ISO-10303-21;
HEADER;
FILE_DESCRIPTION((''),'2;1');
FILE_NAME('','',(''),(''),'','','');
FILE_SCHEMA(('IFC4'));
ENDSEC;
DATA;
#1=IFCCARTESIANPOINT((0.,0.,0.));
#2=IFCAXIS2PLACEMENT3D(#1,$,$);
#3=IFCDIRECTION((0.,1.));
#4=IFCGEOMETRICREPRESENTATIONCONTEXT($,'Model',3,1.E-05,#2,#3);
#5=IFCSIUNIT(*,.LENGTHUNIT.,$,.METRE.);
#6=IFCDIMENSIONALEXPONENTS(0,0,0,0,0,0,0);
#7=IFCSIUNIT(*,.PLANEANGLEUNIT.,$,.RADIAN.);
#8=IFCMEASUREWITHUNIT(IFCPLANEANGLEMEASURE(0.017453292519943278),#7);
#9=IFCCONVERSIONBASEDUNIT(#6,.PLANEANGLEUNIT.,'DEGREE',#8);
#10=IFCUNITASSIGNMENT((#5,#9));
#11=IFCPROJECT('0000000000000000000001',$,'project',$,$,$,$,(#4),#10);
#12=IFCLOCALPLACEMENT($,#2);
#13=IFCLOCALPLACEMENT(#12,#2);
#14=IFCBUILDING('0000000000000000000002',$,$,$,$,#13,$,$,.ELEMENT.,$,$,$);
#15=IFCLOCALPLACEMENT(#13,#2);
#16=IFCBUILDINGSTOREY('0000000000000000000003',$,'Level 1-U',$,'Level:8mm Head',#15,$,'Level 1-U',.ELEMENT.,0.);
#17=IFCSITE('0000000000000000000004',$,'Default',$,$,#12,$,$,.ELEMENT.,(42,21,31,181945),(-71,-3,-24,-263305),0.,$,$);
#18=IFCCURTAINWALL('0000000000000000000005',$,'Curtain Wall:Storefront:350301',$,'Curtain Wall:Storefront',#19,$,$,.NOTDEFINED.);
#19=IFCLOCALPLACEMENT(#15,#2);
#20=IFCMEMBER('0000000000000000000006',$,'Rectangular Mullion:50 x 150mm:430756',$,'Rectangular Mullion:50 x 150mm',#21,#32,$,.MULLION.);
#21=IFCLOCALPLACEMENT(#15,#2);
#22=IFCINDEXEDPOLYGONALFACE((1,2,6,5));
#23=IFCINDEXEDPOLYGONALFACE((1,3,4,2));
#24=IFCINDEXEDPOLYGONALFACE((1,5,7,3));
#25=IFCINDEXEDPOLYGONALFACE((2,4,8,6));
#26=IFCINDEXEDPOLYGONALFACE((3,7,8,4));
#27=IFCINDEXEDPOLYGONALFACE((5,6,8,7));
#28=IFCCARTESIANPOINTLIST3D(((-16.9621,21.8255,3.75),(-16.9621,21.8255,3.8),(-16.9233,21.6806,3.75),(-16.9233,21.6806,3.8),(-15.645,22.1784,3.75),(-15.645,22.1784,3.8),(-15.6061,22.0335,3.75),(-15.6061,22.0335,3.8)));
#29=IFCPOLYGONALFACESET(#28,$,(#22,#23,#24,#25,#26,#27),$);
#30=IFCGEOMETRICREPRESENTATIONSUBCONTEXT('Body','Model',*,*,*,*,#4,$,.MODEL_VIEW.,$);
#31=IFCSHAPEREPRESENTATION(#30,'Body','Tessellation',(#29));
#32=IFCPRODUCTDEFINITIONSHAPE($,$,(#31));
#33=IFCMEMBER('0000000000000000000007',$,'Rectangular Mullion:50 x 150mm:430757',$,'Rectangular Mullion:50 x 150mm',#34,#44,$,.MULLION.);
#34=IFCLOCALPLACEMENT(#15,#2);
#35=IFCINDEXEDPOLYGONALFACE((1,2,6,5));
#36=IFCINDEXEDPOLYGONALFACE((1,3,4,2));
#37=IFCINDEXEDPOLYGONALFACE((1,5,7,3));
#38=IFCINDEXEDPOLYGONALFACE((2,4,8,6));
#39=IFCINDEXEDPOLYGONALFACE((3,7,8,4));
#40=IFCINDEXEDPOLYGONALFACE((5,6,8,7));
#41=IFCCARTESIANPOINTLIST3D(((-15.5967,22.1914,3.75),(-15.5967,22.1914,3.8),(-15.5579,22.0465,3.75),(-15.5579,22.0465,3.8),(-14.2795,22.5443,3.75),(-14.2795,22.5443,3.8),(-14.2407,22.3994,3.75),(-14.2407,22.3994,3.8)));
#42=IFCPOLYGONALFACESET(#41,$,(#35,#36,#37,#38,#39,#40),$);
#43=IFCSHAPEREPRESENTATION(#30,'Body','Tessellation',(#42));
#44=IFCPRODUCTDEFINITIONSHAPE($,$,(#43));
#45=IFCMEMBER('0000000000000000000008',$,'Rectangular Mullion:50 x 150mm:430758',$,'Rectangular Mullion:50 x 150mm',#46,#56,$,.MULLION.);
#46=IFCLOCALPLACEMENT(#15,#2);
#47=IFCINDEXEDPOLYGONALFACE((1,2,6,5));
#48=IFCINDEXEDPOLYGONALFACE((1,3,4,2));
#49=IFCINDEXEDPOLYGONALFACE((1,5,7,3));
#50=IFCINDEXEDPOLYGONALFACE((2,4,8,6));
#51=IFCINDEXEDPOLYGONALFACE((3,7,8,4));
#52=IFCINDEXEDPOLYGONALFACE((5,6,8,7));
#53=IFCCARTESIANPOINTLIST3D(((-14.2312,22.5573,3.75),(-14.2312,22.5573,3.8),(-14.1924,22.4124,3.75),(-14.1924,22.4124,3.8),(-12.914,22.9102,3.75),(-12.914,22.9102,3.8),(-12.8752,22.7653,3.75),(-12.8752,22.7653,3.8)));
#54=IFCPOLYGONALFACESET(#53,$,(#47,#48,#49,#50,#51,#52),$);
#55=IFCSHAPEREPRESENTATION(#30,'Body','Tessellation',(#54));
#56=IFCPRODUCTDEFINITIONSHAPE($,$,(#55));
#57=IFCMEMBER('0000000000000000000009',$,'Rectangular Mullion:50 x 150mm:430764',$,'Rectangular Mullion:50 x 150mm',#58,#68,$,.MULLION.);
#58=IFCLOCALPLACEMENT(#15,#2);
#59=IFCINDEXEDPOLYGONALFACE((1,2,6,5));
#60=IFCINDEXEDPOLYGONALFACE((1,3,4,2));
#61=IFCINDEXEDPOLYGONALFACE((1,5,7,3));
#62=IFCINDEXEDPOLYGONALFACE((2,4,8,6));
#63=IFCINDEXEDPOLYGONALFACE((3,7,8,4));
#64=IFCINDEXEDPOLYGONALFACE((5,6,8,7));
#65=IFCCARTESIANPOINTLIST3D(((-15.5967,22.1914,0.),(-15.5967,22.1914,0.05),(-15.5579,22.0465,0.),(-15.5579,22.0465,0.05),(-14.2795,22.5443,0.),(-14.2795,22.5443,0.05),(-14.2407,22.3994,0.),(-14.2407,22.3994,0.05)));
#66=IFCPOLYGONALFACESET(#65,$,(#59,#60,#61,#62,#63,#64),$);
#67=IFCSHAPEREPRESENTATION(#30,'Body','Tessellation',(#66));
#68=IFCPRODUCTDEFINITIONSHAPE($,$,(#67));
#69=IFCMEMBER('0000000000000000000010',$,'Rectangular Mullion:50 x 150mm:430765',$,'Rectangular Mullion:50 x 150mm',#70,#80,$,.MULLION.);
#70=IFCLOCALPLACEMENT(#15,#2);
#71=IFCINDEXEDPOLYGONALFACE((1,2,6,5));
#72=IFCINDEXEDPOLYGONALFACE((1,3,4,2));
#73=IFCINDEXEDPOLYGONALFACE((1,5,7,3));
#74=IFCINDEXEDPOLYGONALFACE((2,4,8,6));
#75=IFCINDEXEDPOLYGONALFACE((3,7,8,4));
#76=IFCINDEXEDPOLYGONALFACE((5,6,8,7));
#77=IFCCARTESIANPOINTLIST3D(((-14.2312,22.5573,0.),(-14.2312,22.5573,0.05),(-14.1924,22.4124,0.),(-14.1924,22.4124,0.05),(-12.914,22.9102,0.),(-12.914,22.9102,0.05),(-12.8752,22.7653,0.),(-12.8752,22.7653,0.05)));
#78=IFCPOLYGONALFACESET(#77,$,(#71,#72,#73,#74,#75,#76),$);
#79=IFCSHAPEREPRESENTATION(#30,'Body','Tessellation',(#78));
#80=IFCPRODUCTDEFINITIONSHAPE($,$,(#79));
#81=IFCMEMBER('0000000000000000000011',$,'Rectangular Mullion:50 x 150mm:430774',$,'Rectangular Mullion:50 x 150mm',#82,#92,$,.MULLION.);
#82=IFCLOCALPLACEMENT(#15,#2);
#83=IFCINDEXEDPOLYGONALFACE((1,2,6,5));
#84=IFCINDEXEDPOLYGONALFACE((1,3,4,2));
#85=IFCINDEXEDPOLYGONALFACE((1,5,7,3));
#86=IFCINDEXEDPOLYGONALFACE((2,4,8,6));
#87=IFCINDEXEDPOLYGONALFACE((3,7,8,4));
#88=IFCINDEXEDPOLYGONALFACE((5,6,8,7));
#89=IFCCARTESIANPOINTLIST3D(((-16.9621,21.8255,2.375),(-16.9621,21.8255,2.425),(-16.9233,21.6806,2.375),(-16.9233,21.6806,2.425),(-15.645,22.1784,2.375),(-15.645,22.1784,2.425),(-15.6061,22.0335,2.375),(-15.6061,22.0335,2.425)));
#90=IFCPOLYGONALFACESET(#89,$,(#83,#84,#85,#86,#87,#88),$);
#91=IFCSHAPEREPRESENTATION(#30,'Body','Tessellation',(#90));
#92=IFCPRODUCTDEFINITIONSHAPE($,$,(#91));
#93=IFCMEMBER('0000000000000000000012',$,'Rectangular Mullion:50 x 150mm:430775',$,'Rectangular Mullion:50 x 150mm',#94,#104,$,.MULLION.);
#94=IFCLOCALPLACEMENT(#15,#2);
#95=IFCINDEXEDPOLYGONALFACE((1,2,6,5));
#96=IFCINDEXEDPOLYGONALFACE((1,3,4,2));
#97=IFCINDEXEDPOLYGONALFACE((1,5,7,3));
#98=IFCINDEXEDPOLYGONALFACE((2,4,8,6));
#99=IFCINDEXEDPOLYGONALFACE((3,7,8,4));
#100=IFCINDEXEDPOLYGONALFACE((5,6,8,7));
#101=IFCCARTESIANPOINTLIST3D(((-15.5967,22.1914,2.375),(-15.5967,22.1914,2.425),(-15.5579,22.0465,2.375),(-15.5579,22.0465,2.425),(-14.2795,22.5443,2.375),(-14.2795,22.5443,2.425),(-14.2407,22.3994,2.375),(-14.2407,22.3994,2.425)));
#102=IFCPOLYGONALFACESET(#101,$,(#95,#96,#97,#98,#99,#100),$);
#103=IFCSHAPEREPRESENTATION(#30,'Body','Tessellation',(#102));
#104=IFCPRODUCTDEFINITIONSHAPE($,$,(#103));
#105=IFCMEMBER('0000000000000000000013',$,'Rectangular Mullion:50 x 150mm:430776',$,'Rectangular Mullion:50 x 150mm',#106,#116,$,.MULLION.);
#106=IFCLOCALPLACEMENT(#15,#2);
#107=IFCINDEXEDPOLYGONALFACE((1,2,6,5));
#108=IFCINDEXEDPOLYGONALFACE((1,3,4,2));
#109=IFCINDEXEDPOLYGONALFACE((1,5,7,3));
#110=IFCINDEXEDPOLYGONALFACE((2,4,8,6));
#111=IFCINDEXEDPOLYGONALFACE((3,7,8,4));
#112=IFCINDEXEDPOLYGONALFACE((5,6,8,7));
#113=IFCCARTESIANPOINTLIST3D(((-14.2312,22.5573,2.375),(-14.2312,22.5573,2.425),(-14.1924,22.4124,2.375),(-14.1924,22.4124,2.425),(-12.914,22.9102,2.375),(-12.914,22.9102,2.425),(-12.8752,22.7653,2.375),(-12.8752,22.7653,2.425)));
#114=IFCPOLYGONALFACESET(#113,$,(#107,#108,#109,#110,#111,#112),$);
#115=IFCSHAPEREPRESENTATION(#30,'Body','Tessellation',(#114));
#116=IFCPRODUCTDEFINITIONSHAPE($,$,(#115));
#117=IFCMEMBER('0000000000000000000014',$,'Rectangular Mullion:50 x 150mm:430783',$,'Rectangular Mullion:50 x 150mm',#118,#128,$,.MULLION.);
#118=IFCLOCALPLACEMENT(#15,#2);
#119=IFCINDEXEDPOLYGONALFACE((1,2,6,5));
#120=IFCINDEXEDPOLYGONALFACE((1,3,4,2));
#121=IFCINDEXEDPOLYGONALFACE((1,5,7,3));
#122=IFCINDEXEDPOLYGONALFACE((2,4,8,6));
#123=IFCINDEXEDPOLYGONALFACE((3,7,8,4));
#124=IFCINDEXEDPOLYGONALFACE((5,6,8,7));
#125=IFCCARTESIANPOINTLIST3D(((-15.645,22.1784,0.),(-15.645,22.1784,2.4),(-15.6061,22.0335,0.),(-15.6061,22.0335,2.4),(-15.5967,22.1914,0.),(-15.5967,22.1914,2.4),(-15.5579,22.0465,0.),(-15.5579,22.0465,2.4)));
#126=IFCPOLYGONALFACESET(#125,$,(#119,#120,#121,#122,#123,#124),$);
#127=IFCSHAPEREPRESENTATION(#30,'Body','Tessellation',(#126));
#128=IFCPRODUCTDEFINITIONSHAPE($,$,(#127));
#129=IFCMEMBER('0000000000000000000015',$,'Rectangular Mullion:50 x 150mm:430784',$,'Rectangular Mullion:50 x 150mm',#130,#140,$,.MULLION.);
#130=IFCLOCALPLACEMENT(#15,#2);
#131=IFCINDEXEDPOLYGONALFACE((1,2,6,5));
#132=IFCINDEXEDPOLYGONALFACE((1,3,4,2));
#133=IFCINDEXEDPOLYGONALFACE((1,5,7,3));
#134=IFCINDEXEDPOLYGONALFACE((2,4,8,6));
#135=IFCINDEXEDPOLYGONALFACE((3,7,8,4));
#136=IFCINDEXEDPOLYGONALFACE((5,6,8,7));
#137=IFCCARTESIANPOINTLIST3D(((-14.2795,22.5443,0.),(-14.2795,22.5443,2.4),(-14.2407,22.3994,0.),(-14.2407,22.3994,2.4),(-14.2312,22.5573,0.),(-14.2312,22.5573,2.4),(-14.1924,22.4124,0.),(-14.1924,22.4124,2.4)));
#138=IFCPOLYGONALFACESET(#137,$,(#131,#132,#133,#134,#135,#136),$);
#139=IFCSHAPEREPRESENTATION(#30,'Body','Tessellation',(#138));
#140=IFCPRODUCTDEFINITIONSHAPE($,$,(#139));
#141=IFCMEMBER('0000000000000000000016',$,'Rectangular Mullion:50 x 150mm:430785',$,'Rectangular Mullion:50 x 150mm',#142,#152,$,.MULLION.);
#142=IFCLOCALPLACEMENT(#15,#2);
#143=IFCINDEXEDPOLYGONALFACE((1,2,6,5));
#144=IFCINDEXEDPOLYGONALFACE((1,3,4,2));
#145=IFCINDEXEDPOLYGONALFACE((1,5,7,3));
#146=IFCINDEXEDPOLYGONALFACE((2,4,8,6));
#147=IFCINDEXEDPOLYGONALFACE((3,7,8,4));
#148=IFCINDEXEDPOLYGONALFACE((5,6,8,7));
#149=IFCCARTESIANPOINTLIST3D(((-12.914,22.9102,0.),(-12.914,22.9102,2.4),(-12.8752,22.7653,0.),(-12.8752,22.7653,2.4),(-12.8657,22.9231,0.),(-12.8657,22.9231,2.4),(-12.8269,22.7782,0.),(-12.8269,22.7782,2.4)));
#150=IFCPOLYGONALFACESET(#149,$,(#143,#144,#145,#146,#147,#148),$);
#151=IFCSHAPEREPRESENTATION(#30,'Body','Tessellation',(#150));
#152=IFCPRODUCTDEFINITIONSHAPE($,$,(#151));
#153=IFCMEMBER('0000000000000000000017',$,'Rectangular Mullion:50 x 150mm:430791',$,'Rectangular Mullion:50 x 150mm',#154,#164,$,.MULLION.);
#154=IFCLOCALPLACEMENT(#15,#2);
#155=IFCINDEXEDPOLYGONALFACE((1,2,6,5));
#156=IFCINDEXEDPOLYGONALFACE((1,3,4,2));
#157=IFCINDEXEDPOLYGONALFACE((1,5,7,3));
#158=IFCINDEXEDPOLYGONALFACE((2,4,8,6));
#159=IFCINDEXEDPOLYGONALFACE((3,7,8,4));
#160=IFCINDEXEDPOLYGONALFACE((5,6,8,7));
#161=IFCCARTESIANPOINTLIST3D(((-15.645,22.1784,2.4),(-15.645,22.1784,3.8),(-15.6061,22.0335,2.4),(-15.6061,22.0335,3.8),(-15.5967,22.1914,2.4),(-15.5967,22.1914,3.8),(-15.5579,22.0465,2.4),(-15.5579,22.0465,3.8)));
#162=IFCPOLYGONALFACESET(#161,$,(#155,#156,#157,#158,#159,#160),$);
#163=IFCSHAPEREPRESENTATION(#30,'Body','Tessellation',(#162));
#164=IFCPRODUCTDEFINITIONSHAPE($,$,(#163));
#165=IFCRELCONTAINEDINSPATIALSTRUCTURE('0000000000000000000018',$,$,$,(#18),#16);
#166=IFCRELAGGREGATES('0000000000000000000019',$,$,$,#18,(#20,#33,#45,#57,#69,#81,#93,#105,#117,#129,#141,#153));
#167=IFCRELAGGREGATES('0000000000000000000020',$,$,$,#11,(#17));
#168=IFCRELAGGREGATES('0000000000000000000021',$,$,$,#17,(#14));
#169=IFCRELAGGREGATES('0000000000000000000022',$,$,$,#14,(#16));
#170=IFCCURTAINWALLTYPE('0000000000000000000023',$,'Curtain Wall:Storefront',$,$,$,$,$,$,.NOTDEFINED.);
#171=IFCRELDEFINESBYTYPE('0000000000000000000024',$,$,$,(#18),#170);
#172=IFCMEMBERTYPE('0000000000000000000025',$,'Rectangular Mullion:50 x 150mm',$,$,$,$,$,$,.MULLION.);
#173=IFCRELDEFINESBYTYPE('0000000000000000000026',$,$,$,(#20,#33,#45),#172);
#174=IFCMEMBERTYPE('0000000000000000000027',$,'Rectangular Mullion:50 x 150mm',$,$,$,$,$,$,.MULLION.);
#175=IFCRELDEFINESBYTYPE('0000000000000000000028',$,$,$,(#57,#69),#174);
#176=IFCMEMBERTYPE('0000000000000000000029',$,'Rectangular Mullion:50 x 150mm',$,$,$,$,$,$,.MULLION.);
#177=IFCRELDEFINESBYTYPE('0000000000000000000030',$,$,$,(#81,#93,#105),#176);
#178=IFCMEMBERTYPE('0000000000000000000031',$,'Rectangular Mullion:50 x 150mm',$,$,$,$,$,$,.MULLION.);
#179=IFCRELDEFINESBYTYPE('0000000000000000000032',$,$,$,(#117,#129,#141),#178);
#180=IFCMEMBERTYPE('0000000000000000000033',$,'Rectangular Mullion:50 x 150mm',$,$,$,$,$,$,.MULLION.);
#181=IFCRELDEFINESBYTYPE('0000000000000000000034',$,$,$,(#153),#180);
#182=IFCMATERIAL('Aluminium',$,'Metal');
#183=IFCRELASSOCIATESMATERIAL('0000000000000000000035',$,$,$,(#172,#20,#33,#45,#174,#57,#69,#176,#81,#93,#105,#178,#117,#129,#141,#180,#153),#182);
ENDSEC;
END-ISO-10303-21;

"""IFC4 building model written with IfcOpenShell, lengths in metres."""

from ifc_helpers import new_model, entity, si_unit, converted_unit, direction, frame, origin, place, context, subcontext, project, spatial, indexed_curve, outline, extrude, source, transform, mapped, material, type_object, type_shapes, element, aggregate, save


model = new_model("IFC4")

# Units and contexts
model_context = context("Model", 3, precision=1e-05, world=origin(), true_north=direction((0.0, 1.0)))
body_context = subcontext(model_context, "Body", "Model", "MODEL_VIEW")
ifc_project = project(units=[si_unit("LENGTHUNIT", "METRE"), converted_unit("PLANEANGLEUNIT", "DEGREE", entity("IfcPlaneAngleMeasure", 0.017453292519943278), si_unit("PLANEANGLEUNIT", "RADIAN"), dimensions=[0, 0, 0, 0, 0, 0, 0])], contexts=[model_context])

# Site, building, storey
site_placement = place(None, origin())
site = spatial("IfcSite", under=ifc_project, at=site_placement, Name="Default", CompositionType="ELEMENT", RefLatitude=(42, 21, 31, 181945), RefLongitude=(-71, -3, -24, -263305), RefElevation=0.0)
building_placement = place(site_placement, origin())
building = spatial("IfcBuilding", under=site, at=building_placement, CompositionType="ELEMENT")
storey_placement = place(building_placement, origin())
storey = spatial("IfcBuildingStorey", under=building, at=storey_placement, Name="Level 1-U", ObjectType="Level:8mm Head", LongName="Level 1-U", CompositionType="ELEMENT", Elevation=0.0)

# Curtain wall, members
curtain_wall_type = type_object("IfcCurtainWallType", Name="Curtain Wall:Storefront", PredefinedType="NOTDEFINED")
curtain_wall_placement = place(storey_placement, origin())
curtain_wall = element("IfcCurtainWall", 1, at=curtain_wall_placement, inside=storey, type_object=curtain_wall_type, Name="Curtain Wall:Storefront:350301", ObjectType="Curtain Wall:Storefront", PredefinedType="NOTDEFINED")
ifc_material_1 = material(Name="Aluminium", Category="Metal")
member_type_1 = type_object("IfcMemberType", Name="Rectangular Mullion:50 x 150mm", PredefinedType="MULLION", material=ifc_material_1)
shared_shape_1 = source(origin(), body_context, "Body", "SweptSolid", [
    extrude(outline(indexed_curve([(-0.025, -0.075), (0.025, -0.075), (0.025, 0.075), (-0.025, 0.075), (-0.025, -0.075)], self_intersect=False)), frame((-0.025, 0.0, -1.3636), z_axis=(0.0, 0.0, 1.0), x_axis=(-1.0, 0.0, 0.0)), (0.0, 0.0, 1.0), 1.3636),
])
type_shapes(member_type_1, [shared_shape_1])
member_1_placement = place(curtain_wall_placement, frame((-15.6256, 22.106, 3.8), z_axis=(0.965926, 0.258819, 0.0), x_axis=(0.0, 0.0, 1.0)))
member_1 = element("IfcMember", 2, at=member_1_placement, type_object=member_type_1, material=ifc_material_1, Name="Rectangular Mullion:50 x 150mm:430756", ObjectType="Rectangular Mullion:50 x 150mm", PredefinedType="MULLION", context=body_context, shape_type="MappedRepresentation", body=[
    mapped(shared_shape_1, transform((0.0, 0.0, 0.0), scale=1.0)),
])
member_2_placement = place(curtain_wall_placement, frame((-14.2601, 22.4719, 3.8), z_axis=(0.965926, 0.258819, 0.0), x_axis=(0.0, 0.0, 1.0)))
member_2 = element("IfcMember", 3, at=member_2_placement, type_object=member_type_1, material=ifc_material_1, Name="Rectangular Mullion:50 x 150mm:430757", ObjectType="Rectangular Mullion:50 x 150mm", PredefinedType="MULLION", context=body_context, shape_type="MappedRepresentation", body=[
    mapped(shared_shape_1, transform((0.0, 0.0, 0.0), scale=1.0)),
])
member_3_placement = place(curtain_wall_placement, frame((-12.8946, 22.8377, 3.8), z_axis=(0.965926, 0.258819, 0.0), x_axis=(0.0, 0.0, 1.0)))
member_3 = element("IfcMember", 4, at=member_3_placement, type_object=member_type_1, material=ifc_material_1, Name="Rectangular Mullion:50 x 150mm:430758", ObjectType="Rectangular Mullion:50 x 150mm", PredefinedType="MULLION", context=body_context, shape_type="MappedRepresentation", body=[
    mapped(shared_shape_1, transform((0.0, 0.0, 0.0), scale=1.0)),
])
member_type_2 = type_object("IfcMemberType", Name="Rectangular Mullion:50 x 150mm", PredefinedType="MULLION", material=ifc_material_1)
shared_shape_2 = source(origin(), body_context, "Body", "SweptSolid", [
    extrude(outline(indexed_curve([(-0.025, -0.075), (0.025, -0.075), (0.025, 0.075), (-0.025, 0.075), (-0.025, -0.075)], self_intersect=False)), frame((-0.025, 0.0, -1.3636), z_axis=(0.0, 0.0, 1.0), x_axis=(-1.0, 0.0, 0.0)), (0.0, 0.0, 1.0), 1.3636),
])
type_shapes(member_type_2, [shared_shape_2])
member_4_placement = place(curtain_wall_placement, frame((-15.5773, 22.1189, 0.0), z_axis=(-0.965926, -0.258819, 0.0), x_axis=(0.0, 0.0, -1.0)))
member_4 = element("IfcMember", 5, at=member_4_placement, type_object=member_type_2, material=ifc_material_1, Name="Rectangular Mullion:50 x 150mm:430764", ObjectType="Rectangular Mullion:50 x 150mm", PredefinedType="MULLION", context=body_context, shape_type="MappedRepresentation", body=[
    mapped(shared_shape_2, transform((0.0, 0.0, 0.0), scale=1.0)),
])
member_5_placement = place(curtain_wall_placement, frame((-14.2118, 22.4848, 0.0), z_axis=(-0.965926, -0.258819, 0.0), x_axis=(0.0, 0.0, -1.0)))
member_5 = element("IfcMember", 6, at=member_5_placement, type_object=member_type_2, material=ifc_material_1, Name="Rectangular Mullion:50 x 150mm:430765", ObjectType="Rectangular Mullion:50 x 150mm", PredefinedType="MULLION", context=body_context, shape_type="MappedRepresentation", body=[
    mapped(shared_shape_2, transform((0.0, 0.0, 0.0), scale=1.0)),
])
member_type_3 = type_object("IfcMemberType", Name="Rectangular Mullion:50 x 150mm", PredefinedType="MULLION", material=ifc_material_1)
shared_shape_3 = source(origin(), body_context, "Body", "SweptSolid", [
    extrude(outline(indexed_curve([(-0.025, -0.075), (0.025, -0.075), (0.025, 0.075), (-0.025, 0.075), (-0.025, -0.075)], self_intersect=False)), frame((0.0, 0.0, -1.3636), z_axis=(0.0, 0.0, 1.0), x_axis=(-1.0, 0.0, 0.0)), (0.0, 0.0, 1.0), 1.3636),
])
type_shapes(member_type_3, [shared_shape_3])
member_6_placement = place(curtain_wall_placement, frame((-15.6256, 22.106, 2.4), z_axis=(0.965926, 0.258819, 0.0), x_axis=(0.0, 0.0, 1.0)))
member_6 = element("IfcMember", 7, at=member_6_placement, type_object=member_type_3, material=ifc_material_1, Name="Rectangular Mullion:50 x 150mm:430774", ObjectType="Rectangular Mullion:50 x 150mm", PredefinedType="MULLION", context=body_context, shape_type="MappedRepresentation", body=[
    mapped(shared_shape_3, transform((0.0, 0.0, 0.0), scale=1.0)),
])
member_7_placement = place(curtain_wall_placement, frame((-14.2601, 22.4719, 2.4), z_axis=(0.965926, 0.258819, 0.0), x_axis=(0.0, 0.0, 1.0)))
member_7 = element("IfcMember", 8, at=member_7_placement, type_object=member_type_3, material=ifc_material_1, Name="Rectangular Mullion:50 x 150mm:430775", ObjectType="Rectangular Mullion:50 x 150mm", PredefinedType="MULLION", context=body_context, shape_type="MappedRepresentation", body=[
    mapped(shared_shape_3, transform((0.0, 0.0, 0.0), scale=1.0)),
])
member_8_placement = place(curtain_wall_placement, frame((-12.8946, 22.8377, 2.4), z_axis=(0.965926, 0.258819, 0.0), x_axis=(0.0, 0.0, 1.0)))
member_8 = element("IfcMember", 9, at=member_8_placement, type_object=member_type_3, material=ifc_material_1, Name="Rectangular Mullion:50 x 150mm:430776", ObjectType="Rectangular Mullion:50 x 150mm", PredefinedType="MULLION", context=body_context, shape_type="MappedRepresentation", body=[
    mapped(shared_shape_3, transform((0.0, 0.0, 0.0), scale=1.0)),
])
member_type_4 = type_object("IfcMemberType", Name="Rectangular Mullion:50 x 150mm", PredefinedType="MULLION", material=ifc_material_1)
shared_shape_4 = source(origin(), body_context, "Body", "SweptSolid", [
    extrude(outline(indexed_curve([(-0.025, -0.075), (0.025, -0.075), (0.025, 0.075), (-0.025, 0.075), (-0.025, -0.075)], self_intersect=False)), frame((0.0, 0.0, -2.4), z_axis=(0.0, 0.0, 1.0), x_axis=(-1.0, 0.0, 0.0)), (0.0, 0.0, 1.0), 2.4),
])
type_shapes(member_type_4, [shared_shape_4])
member_9_placement = place(curtain_wall_placement, frame((-15.6014, 22.1125, 0.0), z_axis=(0.0, 0.0, -1.0), x_axis=(0.965926, 0.258819, 0.0)))
member_9 = element("IfcMember", 10, at=member_9_placement, type_object=member_type_4, material=ifc_material_1, Name="Rectangular Mullion:50 x 150mm:430783", ObjectType="Rectangular Mullion:50 x 150mm", PredefinedType="MULLION", context=body_context, shape_type="MappedRepresentation", body=[
    mapped(shared_shape_4, transform((0.0, 0.0, 0.0), scale=1.0)),
])
member_10_placement = place(curtain_wall_placement, frame((-14.2359, 22.4783, 0.0), z_axis=(0.0, 0.0, -1.0), x_axis=(0.965926, 0.258819, 0.0)))
member_10 = element("IfcMember", 11, at=member_10_placement, type_object=member_type_4, material=ifc_material_1, Name="Rectangular Mullion:50 x 150mm:430784", ObjectType="Rectangular Mullion:50 x 150mm", PredefinedType="MULLION", context=body_context, shape_type="MappedRepresentation", body=[
    mapped(shared_shape_4, transform((0.0, 0.0, 0.0), scale=1.0)),
])
member_11_placement = place(curtain_wall_placement, frame((-12.8705, 22.8442, 0.0), z_axis=(0.0, 0.0, -1.0), x_axis=(0.965926, 0.258819, 0.0)))
member_11 = element("IfcMember", 12, at=member_11_placement, type_object=member_type_4, material=ifc_material_1, Name="Rectangular Mullion:50 x 150mm:430785", ObjectType="Rectangular Mullion:50 x 150mm", PredefinedType="MULLION", context=body_context, shape_type="MappedRepresentation", body=[
    mapped(shared_shape_4, transform((0.0, 0.0, 0.0), scale=1.0)),
])
member_type_5 = type_object("IfcMemberType", Name="Rectangular Mullion:50 x 150mm", PredefinedType="MULLION", material=ifc_material_1)
shared_shape_5 = source(origin(), body_context, "Body", "SweptSolid", [
    extrude(outline(indexed_curve([(-0.025, -0.075), (0.025, -0.075), (0.025, 0.075), (-0.025, 0.075), (-0.025, -0.075)], self_intersect=False)), frame((0.0, 0.0, -1.4), z_axis=(0.0, 0.0, 1.0), x_axis=(-1.0, 0.0, 0.0)), (0.0, 0.0, 1.0), 1.4),
])
type_shapes(member_type_5, [shared_shape_5])
member_12_placement = place(curtain_wall_placement, frame((-15.6014, 22.1125, 2.4), z_axis=(0.0, 0.0, -1.0), x_axis=(0.965926, 0.258819, 0.0)))
member_12 = element("IfcMember", 13, at=member_12_placement, type_object=member_type_5, material=ifc_material_1, Name="Rectangular Mullion:50 x 150mm:430791", ObjectType="Rectangular Mullion:50 x 150mm", PredefinedType="MULLION", context=body_context, shape_type="MappedRepresentation", body=[
    mapped(shared_shape_5, transform((0.0, 0.0, 0.0), scale=1.0)),
])
aggregate(curtain_wall, [member_1, member_2, member_3, member_4, member_5, member_6, member_7, member_8, member_9, member_10, member_11, member_12])

save(model, "model.ifc")
